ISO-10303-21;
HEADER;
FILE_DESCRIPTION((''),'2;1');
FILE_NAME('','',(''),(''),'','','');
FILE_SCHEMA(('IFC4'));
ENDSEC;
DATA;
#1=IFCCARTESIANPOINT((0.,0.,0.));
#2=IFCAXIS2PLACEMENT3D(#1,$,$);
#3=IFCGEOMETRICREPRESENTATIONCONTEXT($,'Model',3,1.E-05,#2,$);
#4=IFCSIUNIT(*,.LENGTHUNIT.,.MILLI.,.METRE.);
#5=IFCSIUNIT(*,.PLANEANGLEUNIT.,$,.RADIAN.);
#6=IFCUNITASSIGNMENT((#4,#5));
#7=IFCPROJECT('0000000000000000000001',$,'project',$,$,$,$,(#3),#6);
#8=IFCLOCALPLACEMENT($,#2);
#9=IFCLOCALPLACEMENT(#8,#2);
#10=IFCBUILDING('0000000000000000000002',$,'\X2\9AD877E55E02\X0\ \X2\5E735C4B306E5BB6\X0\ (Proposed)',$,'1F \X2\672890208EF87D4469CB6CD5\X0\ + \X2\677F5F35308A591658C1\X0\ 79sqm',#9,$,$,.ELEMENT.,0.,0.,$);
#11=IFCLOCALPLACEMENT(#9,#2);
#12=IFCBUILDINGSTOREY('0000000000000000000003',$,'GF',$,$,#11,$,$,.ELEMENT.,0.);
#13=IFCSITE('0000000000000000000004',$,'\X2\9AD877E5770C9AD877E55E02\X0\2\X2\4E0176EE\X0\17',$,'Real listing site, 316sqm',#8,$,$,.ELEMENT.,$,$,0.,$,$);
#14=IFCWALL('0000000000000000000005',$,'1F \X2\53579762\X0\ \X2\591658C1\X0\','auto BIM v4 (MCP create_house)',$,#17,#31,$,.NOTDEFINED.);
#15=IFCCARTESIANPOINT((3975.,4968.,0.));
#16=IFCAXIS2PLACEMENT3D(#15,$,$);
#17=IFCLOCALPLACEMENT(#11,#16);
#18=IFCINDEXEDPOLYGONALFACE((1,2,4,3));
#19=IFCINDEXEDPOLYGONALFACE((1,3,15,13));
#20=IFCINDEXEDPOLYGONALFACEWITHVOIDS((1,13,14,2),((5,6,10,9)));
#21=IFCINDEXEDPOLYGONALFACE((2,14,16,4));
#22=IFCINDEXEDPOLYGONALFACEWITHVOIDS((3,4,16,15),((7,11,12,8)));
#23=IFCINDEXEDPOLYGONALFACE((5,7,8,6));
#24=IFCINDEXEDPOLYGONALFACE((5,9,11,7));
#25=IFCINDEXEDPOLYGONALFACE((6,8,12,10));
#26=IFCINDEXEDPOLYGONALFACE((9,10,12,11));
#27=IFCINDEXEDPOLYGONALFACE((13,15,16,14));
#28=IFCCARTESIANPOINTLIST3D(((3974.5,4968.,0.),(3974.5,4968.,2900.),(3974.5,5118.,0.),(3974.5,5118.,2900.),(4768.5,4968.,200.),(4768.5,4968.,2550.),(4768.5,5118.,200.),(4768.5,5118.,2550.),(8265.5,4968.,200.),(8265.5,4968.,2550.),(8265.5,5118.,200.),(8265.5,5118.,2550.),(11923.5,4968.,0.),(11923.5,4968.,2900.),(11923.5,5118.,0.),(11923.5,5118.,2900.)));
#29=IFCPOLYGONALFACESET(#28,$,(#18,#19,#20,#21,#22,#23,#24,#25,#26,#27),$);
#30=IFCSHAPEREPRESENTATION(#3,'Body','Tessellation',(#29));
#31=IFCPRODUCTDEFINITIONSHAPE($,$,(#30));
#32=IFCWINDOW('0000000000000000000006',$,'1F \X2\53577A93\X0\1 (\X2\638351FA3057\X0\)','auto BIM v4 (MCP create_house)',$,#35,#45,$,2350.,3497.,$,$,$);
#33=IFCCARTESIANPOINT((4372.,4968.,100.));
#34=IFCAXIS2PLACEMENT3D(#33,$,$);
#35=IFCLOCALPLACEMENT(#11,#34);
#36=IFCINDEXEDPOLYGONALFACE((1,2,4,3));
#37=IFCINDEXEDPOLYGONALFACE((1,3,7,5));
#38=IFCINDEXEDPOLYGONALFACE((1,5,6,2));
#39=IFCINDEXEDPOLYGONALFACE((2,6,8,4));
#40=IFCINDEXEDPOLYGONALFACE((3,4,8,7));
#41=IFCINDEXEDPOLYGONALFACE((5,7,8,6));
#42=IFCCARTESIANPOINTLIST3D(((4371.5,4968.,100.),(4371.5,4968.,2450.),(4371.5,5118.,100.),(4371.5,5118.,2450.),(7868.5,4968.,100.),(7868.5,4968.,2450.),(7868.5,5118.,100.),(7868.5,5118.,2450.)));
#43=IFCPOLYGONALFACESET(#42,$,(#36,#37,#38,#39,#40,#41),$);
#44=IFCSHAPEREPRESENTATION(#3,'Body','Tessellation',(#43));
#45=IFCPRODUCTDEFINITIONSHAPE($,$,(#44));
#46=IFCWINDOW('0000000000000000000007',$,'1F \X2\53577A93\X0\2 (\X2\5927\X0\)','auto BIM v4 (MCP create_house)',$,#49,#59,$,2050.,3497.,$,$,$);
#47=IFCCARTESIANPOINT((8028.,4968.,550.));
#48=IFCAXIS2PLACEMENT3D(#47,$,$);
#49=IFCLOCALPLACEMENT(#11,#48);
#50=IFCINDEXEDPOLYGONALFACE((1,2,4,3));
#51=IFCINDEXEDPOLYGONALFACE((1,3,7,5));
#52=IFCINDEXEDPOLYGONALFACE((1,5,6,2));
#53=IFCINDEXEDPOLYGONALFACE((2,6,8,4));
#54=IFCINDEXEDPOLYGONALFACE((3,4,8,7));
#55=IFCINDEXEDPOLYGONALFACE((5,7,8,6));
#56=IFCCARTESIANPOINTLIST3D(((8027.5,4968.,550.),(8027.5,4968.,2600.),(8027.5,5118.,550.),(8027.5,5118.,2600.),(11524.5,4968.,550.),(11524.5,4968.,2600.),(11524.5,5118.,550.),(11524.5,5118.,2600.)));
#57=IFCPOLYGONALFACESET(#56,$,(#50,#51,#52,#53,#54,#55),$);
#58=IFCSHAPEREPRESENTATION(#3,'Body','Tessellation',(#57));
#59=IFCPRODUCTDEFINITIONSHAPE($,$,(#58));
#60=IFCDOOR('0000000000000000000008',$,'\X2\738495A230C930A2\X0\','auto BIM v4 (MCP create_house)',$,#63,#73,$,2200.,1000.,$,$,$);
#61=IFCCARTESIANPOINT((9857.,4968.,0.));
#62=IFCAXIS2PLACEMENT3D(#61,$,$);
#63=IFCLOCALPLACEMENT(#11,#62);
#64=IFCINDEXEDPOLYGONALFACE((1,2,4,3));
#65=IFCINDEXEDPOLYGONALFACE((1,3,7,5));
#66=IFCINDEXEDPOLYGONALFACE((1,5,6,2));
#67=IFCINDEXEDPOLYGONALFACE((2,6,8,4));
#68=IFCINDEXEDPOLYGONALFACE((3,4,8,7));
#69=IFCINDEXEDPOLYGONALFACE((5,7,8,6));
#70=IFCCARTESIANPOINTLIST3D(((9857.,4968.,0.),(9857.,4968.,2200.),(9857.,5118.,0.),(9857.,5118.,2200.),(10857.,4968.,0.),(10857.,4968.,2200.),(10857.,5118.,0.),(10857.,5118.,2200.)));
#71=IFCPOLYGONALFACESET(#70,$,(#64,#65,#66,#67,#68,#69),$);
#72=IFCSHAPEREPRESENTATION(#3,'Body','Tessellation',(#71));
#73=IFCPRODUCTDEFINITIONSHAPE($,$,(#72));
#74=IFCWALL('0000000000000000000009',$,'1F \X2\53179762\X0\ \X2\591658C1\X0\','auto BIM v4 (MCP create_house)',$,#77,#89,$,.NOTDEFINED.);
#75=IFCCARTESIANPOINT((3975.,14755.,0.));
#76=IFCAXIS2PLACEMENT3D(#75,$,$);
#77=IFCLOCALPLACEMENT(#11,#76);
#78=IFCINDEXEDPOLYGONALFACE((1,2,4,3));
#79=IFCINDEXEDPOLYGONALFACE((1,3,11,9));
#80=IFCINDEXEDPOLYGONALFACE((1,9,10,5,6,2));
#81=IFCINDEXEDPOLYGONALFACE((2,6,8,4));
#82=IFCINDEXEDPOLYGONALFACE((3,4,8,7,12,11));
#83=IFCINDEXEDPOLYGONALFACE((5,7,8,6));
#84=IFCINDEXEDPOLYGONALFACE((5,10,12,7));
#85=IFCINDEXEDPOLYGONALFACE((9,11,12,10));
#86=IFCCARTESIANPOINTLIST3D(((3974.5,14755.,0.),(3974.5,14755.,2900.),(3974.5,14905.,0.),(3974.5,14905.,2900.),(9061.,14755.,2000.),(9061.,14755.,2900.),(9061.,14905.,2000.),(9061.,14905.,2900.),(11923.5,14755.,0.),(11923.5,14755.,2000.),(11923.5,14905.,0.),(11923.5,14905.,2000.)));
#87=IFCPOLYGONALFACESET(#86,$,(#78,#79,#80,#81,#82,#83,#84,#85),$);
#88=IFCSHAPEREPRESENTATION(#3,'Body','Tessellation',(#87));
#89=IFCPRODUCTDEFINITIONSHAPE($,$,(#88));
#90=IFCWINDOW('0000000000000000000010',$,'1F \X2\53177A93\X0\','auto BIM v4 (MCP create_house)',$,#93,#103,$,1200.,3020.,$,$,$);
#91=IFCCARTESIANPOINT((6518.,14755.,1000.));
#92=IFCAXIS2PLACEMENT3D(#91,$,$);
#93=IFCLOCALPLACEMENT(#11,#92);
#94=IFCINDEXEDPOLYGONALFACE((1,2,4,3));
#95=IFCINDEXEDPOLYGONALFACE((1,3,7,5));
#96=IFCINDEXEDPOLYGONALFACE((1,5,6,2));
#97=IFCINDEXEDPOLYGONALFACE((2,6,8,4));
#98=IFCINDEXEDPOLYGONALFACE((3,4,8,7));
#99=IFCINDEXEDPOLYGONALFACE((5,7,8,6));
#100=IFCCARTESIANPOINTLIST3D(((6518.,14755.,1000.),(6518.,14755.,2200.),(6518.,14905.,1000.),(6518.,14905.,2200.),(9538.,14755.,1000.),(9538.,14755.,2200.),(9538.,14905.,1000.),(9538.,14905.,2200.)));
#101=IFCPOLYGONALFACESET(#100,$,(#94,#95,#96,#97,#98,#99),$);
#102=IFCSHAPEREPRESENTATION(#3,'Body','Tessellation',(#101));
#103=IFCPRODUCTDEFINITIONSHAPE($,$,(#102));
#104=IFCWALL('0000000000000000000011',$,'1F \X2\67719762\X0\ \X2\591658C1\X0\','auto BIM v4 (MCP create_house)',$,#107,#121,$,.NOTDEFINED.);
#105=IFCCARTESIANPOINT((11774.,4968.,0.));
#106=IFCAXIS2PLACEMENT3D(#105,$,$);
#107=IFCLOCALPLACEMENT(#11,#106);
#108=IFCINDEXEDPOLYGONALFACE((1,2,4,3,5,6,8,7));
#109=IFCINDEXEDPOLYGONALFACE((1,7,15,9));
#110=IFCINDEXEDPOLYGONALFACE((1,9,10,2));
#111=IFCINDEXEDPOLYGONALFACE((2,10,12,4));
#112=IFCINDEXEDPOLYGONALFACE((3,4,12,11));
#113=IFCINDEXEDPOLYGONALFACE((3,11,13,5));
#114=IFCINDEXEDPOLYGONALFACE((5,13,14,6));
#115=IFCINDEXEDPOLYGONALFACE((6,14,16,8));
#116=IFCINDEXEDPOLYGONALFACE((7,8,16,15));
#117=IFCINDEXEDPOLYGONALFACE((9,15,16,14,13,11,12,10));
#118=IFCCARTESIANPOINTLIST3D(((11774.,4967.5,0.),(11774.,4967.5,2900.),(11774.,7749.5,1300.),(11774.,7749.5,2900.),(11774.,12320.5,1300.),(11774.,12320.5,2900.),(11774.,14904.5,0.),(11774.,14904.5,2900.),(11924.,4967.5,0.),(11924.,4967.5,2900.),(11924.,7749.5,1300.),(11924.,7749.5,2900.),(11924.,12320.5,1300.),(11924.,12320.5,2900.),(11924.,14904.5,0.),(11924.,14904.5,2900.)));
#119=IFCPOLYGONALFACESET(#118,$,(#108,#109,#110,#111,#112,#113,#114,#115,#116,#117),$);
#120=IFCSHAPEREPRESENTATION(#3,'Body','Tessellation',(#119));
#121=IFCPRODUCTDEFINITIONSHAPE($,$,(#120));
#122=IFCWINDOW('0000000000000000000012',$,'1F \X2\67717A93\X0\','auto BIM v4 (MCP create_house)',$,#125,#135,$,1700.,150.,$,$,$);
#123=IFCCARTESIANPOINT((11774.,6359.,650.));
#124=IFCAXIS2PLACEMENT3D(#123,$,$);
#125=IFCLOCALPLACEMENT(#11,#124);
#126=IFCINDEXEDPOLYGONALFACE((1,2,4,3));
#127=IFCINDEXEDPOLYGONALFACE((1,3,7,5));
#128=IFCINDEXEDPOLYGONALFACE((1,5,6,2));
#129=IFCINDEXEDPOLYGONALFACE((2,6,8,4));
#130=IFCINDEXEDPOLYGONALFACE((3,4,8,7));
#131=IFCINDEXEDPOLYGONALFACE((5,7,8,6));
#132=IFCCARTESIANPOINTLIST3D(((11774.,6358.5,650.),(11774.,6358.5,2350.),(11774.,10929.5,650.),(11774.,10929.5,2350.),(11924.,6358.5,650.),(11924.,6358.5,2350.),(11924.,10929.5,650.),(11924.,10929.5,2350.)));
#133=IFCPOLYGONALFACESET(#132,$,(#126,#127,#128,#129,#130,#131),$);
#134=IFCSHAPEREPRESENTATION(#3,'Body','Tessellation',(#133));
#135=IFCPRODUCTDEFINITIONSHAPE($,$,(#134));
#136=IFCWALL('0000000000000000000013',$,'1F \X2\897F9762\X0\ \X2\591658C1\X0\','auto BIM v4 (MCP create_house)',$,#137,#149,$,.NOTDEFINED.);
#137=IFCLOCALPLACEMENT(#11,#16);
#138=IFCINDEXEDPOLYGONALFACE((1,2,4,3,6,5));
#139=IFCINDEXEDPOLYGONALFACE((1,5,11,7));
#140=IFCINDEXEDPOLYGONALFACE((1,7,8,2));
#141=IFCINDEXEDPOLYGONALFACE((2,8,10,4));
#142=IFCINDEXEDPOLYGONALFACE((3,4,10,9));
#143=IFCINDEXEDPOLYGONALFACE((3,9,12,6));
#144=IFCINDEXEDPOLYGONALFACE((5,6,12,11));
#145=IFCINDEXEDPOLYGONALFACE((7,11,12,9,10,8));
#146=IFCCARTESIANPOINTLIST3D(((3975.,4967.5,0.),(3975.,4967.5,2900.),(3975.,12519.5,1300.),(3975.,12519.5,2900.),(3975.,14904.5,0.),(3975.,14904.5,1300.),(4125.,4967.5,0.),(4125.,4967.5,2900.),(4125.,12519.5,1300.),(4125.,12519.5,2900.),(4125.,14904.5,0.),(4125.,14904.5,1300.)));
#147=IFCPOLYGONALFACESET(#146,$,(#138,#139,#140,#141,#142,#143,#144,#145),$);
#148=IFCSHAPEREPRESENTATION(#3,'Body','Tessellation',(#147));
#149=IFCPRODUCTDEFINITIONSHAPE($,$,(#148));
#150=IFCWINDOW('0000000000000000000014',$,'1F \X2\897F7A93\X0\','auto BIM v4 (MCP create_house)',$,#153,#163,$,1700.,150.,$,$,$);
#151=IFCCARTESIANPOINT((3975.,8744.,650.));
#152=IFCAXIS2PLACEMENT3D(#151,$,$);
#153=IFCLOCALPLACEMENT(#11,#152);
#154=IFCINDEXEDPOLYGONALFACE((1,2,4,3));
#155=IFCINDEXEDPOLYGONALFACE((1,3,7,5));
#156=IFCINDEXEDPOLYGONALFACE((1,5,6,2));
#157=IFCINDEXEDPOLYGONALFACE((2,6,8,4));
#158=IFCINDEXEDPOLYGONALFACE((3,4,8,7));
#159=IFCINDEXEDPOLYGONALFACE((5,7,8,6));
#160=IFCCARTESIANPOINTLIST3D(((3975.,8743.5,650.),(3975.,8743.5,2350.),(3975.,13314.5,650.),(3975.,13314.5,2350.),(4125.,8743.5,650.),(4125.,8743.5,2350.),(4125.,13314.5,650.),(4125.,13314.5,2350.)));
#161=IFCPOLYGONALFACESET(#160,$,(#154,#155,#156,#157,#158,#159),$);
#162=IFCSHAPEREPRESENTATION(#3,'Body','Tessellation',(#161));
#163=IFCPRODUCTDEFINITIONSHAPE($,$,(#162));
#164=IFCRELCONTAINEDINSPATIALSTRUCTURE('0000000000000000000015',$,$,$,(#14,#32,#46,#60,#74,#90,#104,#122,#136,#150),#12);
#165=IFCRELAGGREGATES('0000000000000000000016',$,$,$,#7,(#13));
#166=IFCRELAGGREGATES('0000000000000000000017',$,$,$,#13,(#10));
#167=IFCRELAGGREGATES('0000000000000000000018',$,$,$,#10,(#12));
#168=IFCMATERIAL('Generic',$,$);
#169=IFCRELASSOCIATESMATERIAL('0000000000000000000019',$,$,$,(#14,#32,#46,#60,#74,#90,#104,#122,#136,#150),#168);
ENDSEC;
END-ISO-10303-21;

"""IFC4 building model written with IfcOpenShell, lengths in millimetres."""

from ifc_helpers import new_model, si_unit, frame, frame_2d, origin, place, context, project, spatial, rectangle, extrude, material, element, fill, save


model = new_model("IFC4")

# Units and contexts
model_context = context("Model", 3, precision=1e-05, world=origin())
ifc_project = project(units=[si_unit("LENGTHUNIT", "METRE", prefix="MILLI"), si_unit("PLANEANGLEUNIT", "RADIAN")], contexts=[model_context])

# Site, building, storey
site_placement = place(None, origin())
site = spatial("IfcSite", under=ifc_project, at=site_placement, Name="高知県高知市2丁目17", ObjectType="Real listing site, 316sqm", CompositionType="ELEMENT", RefElevation=0.0)
building_placement = place(site_placement, origin())
building = spatial("IfcBuilding", under=site, at=building_placement, Name="高知市 平屋の家 (Proposed)", ObjectType="1F 木造軸組構法 + 板張り外壁 79sqm", CompositionType="ELEMENT", ElevationOfRefHeight=0.0, ElevationOfTerrain=0.0)
storey_placement = place(building_placement, origin())
storey = spatial("IfcBuildingStorey", under=building, at=storey_placement, Name="GF", CompositionType="ELEMENT", Elevation=0.0)

# Shared definitions
ifc_material = material(Name="Generic")

# Wall, openings, windows, door
wall_1_placement = place(storey_placement, frame((3975.0, 4968.0, 0.0)))
wall_1 = element("IfcWall", 1, at=wall_1_placement, inside=storey, material=ifc_material, Name="1F 南面 外壁", Description="auto BIM v4 (MCP create_house)", PredefinedType="NOTDEFINED", context=model_context, shape_type="SweptSolid", body=[
    extrude(rectangle(XDim=7949.0, YDim=150.0, at=frame_2d((3974.0, 75.0))), frame((3975.0, 4968.0, 0.0)), (0.0, 0.0, 1.0), 2900.0),
])
opening_1_placement = place(storey_placement, frame((4372.0, 4968.0, 100.0)))
opening_1 = element("IfcOpeningElement", 2, at=opening_1_placement, cuts=wall_1, PredefinedType="NOTDEFINED", context=model_context, shape_type="SweptSolid", body=[
    extrude(rectangle(XDim=3497.0, YDim=150.0, at=frame_2d((1748.0, 75.0))), frame((4372.0, 4968.0, 100.0)), (0.0, 0.0, 1.0), 2350.0),
])
opening_2_placement = place(storey_placement, frame((8028.0, 4968.0, 550.0)))
opening_2 = element("IfcOpeningElement", 3, at=opening_2_placement, cuts=wall_1, PredefinedType="NOTDEFINED", context=model_context, shape_type="SweptSolid", body=[
    extrude(rectangle(XDim=3497.0, YDim=150.0, at=frame_2d((1748.0, 75.0))), frame((8028.0, 4968.0, 550.0)), (0.0, 0.0, 1.0), 2050.0),
])
opening_3_placement = place(storey_placement, frame((9857.0, 4968.0, 0.0)))
opening_3 = element("IfcOpeningElement", 4, at=opening_3_placement, cuts=wall_1, PredefinedType="NOTDEFINED", context=model_context, shape_type="SweptSolid", body=[
    extrude(rectangle(XDim=1000.0, YDim=150.0, at=frame_2d((500.0, 75.0))), frame((9857.0, 4968.0, 0.0)), (0.0, 0.0, 1.0), 2200.0),
])
window_1_placement = place(storey_placement, frame((4372.0, 4968.0, 100.0)))
window_1 = element("IfcWindow", 5, at=window_1_placement, inside=storey, material=ifc_material, Name="1F 南窓1 (掃出し)", Description="auto BIM v4 (MCP create_house)", OverallHeight=2350.0, OverallWidth=3497.0, context=model_context, shape_type="SweptSolid", body=[
    extrude(rectangle(XDim=3497.0, YDim=150.0, at=frame_2d((1748.0, 75.0))), frame((4372.0, 4968.0, 100.0)), (0.0, 0.0, 1.0), 2350.0),
])
fill(opening_1, window_1)
window_2_placement = place(storey_placement, frame((8028.0, 4968.0, 550.0)))
window_2 = element("IfcWindow", 6, at=window_2_placement, inside=storey, material=ifc_material, Name="1F 南窓2 (大)", Description="auto BIM v4 (MCP create_house)", OverallHeight=2050.0, OverallWidth=3497.0, context=model_context, shape_type="SweptSolid", body=[
    extrude(rectangle(XDim=3497.0, YDim=150.0, at=frame_2d((1748.0, 75.0))), frame((8028.0, 4968.0, 550.0)), (0.0, 0.0, 1.0), 2050.0),
])
fill(opening_2, window_2)
door_placement = place(storey_placement, frame((9857.0, 4968.0, 0.0)))
door = element("IfcDoor", 7, at=door_placement, inside=storey, material=ifc_material, Name="玄関ドア", Description="auto BIM v4 (MCP create_house)", OverallHeight=2200.0, OverallWidth=1000.0, context=model_context, shape_type="SweptSolid", body=[
    extrude(rectangle(XDim=1000.0, YDim=150.0, at=frame_2d((500.0, 75.0))), frame((9857.0, 4968.0, 0.0)), (0.0, 0.0, 1.0), 2200.0),
])
fill(opening_3, door)

# Walls, openings, windows
wall_2_placement = place(storey_placement, frame((3975.0, 14755.0, 0.0)))
wall_2 = element("IfcWall", 8, at=wall_2_placement, inside=storey, material=ifc_material, Name="1F 北面 外壁", Description="auto BIM v4 (MCP create_house)", PredefinedType="NOTDEFINED", context=model_context, shape_type="SweptSolid", body=[
    extrude(rectangle(XDim=7949.0, YDim=150.0, at=frame_2d((3974.0, 75.0))), frame((3975.0, 14755.0, 0.0)), (0.0, 0.0, 1.0), 2900.0),
])
opening_4_placement = place(storey_placement, frame((6518.0, 14755.0, 1000.0)))
opening_4 = element("IfcOpeningElement", 9, at=opening_4_placement, cuts=wall_2, PredefinedType="NOTDEFINED", context=model_context, shape_type="SweptSolid", body=[
    extrude(rectangle(XDim=3020.0, YDim=150.0, at=frame_2d((1510.0, 75.0))), frame((6518.0, 14755.0, 1000.0)), (0.0, 0.0, 1.0), 1200.0),
])
window_3_placement = place(storey_placement, frame((6518.0, 14755.0, 1000.0)))
window_3 = element("IfcWindow", 10, at=window_3_placement, inside=storey, material=ifc_material, Name="1F 北窓", Description="auto BIM v4 (MCP create_house)", OverallHeight=1200.0, OverallWidth=3020.0, context=model_context, shape_type="SweptSolid", body=[
    extrude(rectangle(XDim=3020.0, YDim=150.0, at=frame_2d((1510.0, 75.0))), frame((6518.0, 14755.0, 1000.0)), (0.0, 0.0, 1.0), 1200.0),
])
fill(opening_4, window_3)
wall_3_placement = place(storey_placement, frame((11774.0, 4968.0, 0.0)))
wall_3 = element("IfcWall", 11, at=wall_3_placement, inside=storey, material=ifc_material, Name="1F 東面 外壁", Description="auto BIM v4 (MCP create_house)", PredefinedType="NOTDEFINED", context=model_context, shape_type="SweptSolid", body=[
    extrude(rectangle(XDim=150.0, YDim=9937.0, at=frame_2d((75.0, 4968.0))), frame((11774.0, 4968.0, 0.0)), (0.0, 0.0, 1.0), 2900.0),
])
opening_5_placement = place(storey_placement, frame((11774.0, 6359.0, 650.0)))
opening_5 = element("IfcOpeningElement", 12, at=opening_5_placement, cuts=wall_3, PredefinedType="NOTDEFINED", context=model_context, shape_type="SweptSolid", body=[
    extrude(rectangle(XDim=150.0, YDim=4571.0, at=frame_2d((75.0, 2285.0))), frame((11774.0, 6359.0, 650.0)), (0.0, 0.0, 1.0), 1700.0),
])
window_4_placement = place(storey_placement, frame((11774.0, 6359.0, 650.0)))
window_4 = element("IfcWindow", 13, at=window_4_placement, inside=storey, material=ifc_material, Name="1F 東窓", Description="auto BIM v4 (MCP create_house)", OverallHeight=1700.0, OverallWidth=150.0, context=model_context, shape_type="SweptSolid", body=[
    extrude(rectangle(XDim=150.0, YDim=4571.0, at=frame_2d((75.0, 2285.0))), frame((11774.0, 6359.0, 650.0)), (0.0, 0.0, 1.0), 1700.0),
])
fill(opening_5, window_4)
wall_4_placement = place(storey_placement, frame((3975.0, 4968.0, 0.0)))
wall_4 = element("IfcWall", 14, at=wall_4_placement, inside=storey, material=ifc_material, Name="1F 西面 外壁", Description="auto BIM v4 (MCP create_house)", PredefinedType="NOTDEFINED", context=model_context, shape_type="SweptSolid", body=[
    extrude(rectangle(XDim=150.0, YDim=9937.0, at=frame_2d((75.0, 4968.0))), frame((3975.0, 4968.0, 0.0)), (0.0, 0.0, 1.0), 2900.0),
])
opening_6_placement = place(storey_placement, frame((3975.0, 8744.0, 650.0)))
opening_6 = element("IfcOpeningElement", 15, at=opening_6_placement, cuts=wall_4, PredefinedType="NOTDEFINED", context=model_context, shape_type="SweptSolid", body=[
    extrude(rectangle(XDim=150.0, YDim=4571.0, at=frame_2d((75.0, 2285.0))), frame((3975.0, 8744.0, 650.0)), (0.0, 0.0, 1.0), 1700.0),
])
window_5_placement = place(storey_placement, frame((3975.0, 8744.0, 650.0)))
window_5 = element("IfcWindow", 16, at=window_5_placement, inside=storey, material=ifc_material, Name="1F 西窓", Description="auto BIM v4 (MCP create_house)", OverallHeight=1700.0, OverallWidth=150.0, context=model_context, shape_type="SweptSolid", body=[
    extrude(rectangle(XDim=150.0, YDim=4571.0, at=frame_2d((75.0, 2285.0))), frame((3975.0, 8744.0, 650.0)), (0.0, 0.0, 1.0), 1700.0),
])
fill(opening_6, window_5)

save(model, "model.ifc")
